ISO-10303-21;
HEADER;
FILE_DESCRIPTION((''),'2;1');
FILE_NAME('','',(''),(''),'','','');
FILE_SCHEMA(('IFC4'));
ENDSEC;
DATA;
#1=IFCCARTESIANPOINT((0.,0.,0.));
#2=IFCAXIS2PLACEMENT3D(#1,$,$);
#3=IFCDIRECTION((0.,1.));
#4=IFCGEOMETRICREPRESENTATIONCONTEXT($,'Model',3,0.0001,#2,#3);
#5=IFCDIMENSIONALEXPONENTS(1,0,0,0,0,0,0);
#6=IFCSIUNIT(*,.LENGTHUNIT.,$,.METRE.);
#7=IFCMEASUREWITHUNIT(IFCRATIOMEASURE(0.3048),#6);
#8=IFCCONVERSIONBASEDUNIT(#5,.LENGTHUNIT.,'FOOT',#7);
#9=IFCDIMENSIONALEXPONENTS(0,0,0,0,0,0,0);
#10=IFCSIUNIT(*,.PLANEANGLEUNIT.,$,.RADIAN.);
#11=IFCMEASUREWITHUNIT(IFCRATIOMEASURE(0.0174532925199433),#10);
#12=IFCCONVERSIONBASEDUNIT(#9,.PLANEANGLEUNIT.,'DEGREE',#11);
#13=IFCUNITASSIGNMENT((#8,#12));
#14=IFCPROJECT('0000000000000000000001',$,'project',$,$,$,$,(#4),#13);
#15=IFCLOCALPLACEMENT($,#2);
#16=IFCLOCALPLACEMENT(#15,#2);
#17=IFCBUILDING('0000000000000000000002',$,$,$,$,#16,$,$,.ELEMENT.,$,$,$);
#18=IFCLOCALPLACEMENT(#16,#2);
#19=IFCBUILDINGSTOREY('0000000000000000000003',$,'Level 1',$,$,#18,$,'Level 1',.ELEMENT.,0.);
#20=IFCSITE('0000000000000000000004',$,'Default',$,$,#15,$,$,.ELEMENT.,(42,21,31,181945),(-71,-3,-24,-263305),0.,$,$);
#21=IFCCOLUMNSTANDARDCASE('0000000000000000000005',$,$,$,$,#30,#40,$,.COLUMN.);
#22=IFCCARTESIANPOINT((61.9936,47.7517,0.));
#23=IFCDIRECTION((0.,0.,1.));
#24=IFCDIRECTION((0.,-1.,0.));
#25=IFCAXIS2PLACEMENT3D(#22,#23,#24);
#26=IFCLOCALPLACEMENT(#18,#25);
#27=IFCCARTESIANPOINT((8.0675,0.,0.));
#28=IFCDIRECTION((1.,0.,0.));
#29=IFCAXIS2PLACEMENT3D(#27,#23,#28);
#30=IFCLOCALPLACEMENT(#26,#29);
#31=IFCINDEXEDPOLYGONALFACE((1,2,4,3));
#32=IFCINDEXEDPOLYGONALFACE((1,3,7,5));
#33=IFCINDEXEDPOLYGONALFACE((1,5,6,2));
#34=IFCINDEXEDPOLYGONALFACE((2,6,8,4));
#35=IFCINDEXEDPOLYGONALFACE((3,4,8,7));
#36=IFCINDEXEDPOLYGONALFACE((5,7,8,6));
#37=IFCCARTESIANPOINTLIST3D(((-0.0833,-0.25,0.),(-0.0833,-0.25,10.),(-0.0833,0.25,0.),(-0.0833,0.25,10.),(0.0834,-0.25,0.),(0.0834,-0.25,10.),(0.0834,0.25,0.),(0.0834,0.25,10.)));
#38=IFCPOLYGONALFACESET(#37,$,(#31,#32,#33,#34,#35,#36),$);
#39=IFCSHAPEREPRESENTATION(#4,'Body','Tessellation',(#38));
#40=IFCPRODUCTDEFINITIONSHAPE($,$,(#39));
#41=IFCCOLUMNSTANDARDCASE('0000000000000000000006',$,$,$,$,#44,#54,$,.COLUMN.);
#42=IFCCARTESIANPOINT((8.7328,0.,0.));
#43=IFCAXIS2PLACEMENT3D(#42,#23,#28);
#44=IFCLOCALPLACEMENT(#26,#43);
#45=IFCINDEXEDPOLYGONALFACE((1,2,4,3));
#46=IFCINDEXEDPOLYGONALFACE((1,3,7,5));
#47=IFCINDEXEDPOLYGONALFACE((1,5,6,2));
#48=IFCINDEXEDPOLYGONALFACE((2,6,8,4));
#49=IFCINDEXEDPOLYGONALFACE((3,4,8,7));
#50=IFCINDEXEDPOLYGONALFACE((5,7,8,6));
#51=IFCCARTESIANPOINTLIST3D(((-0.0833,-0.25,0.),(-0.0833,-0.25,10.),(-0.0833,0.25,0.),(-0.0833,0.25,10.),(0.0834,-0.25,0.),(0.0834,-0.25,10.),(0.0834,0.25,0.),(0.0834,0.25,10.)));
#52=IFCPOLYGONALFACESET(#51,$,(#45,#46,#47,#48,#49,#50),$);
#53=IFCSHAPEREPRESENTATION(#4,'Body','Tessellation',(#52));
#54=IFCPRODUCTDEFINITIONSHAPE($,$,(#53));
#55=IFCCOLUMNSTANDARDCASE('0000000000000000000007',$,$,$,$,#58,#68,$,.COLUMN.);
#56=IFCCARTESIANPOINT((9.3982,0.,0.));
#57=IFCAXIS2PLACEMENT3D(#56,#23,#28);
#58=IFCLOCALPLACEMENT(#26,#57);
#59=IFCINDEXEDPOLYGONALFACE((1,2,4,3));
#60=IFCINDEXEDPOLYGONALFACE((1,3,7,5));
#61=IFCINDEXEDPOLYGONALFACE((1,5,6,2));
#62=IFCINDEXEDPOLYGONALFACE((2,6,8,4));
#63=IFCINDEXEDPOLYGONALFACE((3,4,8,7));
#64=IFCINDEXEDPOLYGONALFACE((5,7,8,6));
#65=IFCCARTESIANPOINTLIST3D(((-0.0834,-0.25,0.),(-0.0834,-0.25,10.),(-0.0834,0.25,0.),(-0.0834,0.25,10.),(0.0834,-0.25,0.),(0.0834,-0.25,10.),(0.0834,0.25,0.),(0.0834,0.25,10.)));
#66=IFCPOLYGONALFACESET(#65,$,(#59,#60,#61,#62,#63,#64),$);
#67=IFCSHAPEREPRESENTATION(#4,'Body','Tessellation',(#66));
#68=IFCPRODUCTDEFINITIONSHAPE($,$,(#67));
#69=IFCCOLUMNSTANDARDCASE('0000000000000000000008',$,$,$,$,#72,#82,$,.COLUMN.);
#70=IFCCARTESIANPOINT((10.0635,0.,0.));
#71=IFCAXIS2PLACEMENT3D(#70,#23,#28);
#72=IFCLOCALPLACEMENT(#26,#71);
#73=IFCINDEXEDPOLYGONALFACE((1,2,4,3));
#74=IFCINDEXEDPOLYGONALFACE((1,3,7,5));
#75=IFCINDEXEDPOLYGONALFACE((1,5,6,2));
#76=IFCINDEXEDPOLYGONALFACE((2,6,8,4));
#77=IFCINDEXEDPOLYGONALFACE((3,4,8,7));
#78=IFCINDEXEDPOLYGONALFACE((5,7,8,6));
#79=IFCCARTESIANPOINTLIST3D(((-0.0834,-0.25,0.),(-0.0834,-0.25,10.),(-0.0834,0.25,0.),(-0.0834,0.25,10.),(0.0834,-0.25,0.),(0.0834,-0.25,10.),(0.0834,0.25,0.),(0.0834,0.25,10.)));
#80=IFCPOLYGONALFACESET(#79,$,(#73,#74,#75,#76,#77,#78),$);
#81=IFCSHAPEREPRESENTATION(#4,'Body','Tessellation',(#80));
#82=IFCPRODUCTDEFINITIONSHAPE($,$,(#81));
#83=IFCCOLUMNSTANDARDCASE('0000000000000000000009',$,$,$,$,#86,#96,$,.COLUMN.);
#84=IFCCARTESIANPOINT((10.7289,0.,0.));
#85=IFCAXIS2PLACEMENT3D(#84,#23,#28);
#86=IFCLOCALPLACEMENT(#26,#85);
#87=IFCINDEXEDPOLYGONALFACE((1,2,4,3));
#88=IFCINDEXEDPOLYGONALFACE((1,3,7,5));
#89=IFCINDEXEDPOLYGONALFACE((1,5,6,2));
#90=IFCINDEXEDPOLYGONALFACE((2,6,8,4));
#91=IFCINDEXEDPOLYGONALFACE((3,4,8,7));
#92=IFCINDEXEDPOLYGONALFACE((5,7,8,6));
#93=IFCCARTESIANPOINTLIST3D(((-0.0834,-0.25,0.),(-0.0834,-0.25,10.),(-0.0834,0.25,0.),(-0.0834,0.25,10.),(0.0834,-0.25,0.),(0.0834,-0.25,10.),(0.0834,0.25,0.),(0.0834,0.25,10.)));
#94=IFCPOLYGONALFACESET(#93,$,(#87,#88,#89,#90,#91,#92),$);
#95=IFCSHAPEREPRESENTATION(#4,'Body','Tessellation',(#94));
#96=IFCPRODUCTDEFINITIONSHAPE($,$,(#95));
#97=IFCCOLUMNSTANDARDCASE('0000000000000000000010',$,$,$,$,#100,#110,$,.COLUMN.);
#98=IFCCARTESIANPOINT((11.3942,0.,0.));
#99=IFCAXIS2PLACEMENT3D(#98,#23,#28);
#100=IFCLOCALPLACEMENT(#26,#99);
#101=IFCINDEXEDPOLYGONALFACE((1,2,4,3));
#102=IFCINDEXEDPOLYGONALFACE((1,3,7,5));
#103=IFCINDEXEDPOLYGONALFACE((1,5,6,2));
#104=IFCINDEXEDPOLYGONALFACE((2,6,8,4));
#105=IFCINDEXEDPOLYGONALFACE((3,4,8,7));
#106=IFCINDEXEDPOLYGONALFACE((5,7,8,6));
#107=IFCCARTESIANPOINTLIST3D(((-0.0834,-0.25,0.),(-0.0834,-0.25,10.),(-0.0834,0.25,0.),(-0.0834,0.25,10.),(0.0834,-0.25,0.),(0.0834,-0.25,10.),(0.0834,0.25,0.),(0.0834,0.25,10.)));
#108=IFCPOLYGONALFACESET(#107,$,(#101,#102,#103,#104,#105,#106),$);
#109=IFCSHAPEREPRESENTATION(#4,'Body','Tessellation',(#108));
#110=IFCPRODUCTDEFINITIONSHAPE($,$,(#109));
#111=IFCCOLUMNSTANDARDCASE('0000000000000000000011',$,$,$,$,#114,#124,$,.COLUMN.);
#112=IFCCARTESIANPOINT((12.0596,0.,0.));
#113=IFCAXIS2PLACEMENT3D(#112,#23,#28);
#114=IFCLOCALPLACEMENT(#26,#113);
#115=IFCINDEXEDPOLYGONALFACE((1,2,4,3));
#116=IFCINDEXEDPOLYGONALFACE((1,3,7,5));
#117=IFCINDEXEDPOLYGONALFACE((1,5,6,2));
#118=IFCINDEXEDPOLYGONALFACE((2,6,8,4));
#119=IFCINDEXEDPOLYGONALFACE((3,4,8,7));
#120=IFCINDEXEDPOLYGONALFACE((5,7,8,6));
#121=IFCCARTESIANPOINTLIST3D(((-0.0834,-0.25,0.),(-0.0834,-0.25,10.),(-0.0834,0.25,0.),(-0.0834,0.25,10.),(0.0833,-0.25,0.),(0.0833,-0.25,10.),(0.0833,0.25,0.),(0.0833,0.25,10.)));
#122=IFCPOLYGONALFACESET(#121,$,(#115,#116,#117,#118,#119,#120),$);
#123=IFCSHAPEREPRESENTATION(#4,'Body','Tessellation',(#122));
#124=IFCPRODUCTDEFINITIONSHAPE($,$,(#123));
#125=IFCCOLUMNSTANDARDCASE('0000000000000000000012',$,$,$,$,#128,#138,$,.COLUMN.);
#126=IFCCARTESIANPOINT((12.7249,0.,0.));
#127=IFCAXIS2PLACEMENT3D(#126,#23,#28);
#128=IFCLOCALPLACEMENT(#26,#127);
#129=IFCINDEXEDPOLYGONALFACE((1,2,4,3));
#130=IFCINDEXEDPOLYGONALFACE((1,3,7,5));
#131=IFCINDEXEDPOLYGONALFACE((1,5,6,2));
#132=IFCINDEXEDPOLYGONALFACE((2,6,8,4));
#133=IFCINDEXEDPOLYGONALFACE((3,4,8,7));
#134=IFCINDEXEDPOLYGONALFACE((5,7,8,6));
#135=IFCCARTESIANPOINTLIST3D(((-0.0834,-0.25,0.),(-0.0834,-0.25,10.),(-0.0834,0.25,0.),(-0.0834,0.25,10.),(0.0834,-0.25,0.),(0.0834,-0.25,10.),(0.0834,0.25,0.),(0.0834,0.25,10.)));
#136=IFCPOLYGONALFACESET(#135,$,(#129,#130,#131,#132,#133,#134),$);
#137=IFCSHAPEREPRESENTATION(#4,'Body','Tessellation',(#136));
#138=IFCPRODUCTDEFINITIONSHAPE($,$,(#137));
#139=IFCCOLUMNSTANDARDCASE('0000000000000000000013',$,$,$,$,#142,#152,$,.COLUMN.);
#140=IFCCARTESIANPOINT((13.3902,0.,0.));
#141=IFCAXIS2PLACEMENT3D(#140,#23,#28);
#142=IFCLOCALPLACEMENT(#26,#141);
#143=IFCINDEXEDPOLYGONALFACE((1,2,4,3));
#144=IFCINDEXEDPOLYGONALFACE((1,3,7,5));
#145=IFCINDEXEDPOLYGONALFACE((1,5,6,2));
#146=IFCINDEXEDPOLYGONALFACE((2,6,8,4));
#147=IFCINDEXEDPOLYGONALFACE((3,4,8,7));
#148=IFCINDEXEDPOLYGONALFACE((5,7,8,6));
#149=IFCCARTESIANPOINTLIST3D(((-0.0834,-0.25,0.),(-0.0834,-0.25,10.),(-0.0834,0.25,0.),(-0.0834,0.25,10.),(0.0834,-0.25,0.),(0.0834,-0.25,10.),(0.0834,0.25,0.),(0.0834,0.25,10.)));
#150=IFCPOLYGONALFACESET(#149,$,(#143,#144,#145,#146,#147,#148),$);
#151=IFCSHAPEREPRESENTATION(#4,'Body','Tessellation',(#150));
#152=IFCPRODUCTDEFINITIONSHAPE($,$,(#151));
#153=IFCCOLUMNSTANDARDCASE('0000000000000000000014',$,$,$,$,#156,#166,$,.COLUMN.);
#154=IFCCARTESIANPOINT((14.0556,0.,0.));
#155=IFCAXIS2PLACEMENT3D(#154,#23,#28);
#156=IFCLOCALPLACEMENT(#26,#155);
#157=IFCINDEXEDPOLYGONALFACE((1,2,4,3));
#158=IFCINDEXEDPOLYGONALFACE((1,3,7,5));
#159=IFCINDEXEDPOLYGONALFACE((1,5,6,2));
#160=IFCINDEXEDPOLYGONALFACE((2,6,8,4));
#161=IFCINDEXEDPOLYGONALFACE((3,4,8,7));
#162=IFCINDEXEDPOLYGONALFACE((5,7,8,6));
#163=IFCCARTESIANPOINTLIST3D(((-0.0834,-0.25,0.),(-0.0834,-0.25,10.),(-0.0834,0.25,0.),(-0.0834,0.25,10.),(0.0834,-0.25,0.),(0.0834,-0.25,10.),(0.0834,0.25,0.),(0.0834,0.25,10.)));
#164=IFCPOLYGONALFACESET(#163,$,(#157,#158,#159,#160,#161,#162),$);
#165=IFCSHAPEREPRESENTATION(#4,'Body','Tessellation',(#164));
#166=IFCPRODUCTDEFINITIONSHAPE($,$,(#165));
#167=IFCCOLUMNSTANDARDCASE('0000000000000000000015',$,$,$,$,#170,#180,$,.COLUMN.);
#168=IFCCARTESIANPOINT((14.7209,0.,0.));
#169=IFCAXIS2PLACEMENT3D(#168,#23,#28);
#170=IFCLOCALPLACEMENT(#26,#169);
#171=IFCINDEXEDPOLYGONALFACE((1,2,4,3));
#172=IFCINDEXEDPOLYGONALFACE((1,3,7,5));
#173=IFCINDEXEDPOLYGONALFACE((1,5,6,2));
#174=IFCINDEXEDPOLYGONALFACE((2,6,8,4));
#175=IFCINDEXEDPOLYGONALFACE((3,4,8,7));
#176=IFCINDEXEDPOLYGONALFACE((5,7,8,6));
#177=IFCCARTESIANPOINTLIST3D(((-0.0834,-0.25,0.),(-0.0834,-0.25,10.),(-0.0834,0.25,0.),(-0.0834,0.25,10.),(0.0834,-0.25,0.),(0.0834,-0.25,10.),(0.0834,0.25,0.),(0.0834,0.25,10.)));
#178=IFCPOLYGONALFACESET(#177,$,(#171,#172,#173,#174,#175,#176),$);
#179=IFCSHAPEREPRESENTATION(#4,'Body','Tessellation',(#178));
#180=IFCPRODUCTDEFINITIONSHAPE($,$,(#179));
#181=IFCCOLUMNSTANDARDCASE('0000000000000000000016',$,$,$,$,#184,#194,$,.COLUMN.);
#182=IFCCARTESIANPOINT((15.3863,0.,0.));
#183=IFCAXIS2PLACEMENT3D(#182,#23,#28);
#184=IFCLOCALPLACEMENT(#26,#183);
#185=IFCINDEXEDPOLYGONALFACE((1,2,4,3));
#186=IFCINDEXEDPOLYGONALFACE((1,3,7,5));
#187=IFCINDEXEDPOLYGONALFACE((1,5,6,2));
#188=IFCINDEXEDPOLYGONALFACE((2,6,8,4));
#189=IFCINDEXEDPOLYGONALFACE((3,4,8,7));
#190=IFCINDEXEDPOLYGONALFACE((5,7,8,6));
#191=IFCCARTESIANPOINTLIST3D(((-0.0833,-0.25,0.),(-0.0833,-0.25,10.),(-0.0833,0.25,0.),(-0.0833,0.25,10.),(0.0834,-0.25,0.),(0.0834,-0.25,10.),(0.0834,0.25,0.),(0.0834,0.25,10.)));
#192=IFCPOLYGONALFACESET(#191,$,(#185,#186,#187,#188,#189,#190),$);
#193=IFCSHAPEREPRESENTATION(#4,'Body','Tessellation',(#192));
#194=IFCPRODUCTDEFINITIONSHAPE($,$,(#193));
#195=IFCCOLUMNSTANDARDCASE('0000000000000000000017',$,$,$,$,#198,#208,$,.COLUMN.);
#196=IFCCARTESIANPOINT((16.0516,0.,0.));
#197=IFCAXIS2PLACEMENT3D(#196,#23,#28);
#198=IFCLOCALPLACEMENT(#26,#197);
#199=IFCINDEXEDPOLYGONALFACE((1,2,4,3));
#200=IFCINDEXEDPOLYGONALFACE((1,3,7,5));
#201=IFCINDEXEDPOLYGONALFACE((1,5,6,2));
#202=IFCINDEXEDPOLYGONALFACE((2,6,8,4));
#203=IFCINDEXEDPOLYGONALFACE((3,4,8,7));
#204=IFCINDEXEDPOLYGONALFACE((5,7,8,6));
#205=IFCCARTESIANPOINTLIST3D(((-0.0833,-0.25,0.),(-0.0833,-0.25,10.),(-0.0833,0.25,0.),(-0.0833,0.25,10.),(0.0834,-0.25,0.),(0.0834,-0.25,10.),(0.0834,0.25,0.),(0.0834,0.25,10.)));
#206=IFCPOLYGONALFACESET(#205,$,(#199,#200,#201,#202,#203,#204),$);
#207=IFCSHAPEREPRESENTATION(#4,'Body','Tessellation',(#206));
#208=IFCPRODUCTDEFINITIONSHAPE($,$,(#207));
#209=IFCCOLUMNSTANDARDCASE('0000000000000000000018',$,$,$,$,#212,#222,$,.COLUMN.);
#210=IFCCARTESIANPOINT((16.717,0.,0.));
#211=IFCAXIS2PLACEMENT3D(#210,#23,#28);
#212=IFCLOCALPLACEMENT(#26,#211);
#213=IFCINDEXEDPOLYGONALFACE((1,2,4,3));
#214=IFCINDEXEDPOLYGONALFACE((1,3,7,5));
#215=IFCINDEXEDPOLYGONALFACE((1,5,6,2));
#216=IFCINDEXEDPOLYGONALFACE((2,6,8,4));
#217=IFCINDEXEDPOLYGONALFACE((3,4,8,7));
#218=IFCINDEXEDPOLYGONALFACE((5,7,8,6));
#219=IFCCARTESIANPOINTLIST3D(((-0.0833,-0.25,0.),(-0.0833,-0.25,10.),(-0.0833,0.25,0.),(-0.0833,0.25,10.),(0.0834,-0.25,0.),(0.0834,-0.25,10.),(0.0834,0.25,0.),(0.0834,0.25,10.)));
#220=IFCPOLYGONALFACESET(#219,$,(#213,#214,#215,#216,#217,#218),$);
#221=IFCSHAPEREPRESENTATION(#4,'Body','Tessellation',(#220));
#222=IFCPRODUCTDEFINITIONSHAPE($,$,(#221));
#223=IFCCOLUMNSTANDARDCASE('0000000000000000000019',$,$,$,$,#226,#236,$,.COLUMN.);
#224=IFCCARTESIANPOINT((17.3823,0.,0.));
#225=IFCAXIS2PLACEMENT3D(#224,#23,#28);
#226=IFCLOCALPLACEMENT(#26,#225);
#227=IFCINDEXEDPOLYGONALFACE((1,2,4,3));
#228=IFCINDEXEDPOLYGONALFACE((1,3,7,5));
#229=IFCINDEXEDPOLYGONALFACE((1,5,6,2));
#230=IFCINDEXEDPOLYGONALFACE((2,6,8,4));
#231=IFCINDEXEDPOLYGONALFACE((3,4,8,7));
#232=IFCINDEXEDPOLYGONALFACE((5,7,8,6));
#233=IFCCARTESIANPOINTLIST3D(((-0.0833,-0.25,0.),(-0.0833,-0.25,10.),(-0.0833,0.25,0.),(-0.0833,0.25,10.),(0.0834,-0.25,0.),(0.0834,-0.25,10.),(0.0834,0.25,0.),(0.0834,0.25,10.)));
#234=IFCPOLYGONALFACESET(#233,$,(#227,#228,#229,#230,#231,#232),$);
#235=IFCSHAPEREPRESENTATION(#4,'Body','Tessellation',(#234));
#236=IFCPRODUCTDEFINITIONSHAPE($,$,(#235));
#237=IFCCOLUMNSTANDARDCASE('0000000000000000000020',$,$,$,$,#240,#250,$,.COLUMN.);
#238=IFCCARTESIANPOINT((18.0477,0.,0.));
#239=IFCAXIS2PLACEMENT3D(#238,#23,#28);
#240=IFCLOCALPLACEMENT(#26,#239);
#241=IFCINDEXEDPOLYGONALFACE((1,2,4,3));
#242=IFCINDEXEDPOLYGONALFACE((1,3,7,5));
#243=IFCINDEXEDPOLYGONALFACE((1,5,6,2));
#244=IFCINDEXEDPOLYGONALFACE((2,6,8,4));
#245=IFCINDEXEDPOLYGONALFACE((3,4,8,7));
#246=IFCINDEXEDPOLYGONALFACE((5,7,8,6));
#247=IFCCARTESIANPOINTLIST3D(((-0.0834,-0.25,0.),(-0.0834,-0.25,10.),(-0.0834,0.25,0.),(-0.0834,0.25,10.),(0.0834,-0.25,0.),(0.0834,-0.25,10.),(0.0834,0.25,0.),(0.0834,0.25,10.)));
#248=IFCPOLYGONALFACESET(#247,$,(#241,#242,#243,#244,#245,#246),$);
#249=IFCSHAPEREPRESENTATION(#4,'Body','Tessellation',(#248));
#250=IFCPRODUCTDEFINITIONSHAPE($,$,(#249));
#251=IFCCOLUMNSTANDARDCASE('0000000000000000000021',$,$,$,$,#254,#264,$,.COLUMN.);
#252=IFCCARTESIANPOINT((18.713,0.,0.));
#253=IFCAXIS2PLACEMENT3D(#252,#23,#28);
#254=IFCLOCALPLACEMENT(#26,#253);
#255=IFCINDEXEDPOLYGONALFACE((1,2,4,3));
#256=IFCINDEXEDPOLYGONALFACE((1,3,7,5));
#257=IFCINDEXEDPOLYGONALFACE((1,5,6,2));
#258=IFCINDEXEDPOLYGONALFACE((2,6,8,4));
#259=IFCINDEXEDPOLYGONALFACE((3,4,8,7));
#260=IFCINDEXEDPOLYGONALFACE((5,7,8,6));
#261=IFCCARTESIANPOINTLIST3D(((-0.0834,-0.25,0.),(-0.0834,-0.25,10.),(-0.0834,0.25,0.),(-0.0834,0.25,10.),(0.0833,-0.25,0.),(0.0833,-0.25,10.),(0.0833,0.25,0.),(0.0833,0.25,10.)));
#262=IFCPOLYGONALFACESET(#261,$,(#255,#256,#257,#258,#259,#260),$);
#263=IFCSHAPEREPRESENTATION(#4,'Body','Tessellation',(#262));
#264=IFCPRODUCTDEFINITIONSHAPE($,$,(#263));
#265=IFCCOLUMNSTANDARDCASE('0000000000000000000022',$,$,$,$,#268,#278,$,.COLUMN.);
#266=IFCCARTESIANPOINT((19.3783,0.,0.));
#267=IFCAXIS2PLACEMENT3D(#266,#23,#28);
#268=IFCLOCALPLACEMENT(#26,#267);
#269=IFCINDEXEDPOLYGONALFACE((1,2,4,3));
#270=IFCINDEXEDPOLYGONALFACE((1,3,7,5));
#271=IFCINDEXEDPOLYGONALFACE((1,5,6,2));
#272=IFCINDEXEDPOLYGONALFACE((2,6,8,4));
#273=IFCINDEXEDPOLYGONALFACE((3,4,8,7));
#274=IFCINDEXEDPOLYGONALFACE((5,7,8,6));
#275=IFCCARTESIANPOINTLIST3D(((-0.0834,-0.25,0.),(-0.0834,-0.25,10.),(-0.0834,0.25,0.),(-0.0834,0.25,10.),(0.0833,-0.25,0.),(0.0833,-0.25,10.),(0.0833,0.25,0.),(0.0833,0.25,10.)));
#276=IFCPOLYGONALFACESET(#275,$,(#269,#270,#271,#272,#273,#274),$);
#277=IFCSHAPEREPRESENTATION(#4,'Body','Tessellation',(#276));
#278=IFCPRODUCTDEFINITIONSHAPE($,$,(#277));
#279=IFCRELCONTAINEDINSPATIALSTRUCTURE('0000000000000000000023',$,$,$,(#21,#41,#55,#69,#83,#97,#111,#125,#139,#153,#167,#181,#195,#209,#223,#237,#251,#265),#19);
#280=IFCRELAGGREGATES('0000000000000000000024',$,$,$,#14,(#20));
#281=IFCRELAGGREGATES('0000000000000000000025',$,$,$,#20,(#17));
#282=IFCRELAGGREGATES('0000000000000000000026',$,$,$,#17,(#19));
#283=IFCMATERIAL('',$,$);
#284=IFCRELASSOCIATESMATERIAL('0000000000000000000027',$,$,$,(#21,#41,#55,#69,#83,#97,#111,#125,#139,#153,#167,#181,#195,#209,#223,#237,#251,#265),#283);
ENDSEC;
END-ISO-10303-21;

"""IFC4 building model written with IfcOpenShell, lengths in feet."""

from ifc_helpers import new_model, entity, si_unit, converted_unit, direction, frame, origin, place, context, project, spatial, rectangle, extrude, material, element, save


model = new_model("IFC4")

# Units and contexts
model_context = context("Model", 3, precision=0.0001, world=origin(), true_north=direction((0.0, 1.0)))
ifc_project = project(units=[converted_unit("LENGTHUNIT", "FOOT", entity("IfcRatioMeasure", 0.3048), si_unit("LENGTHUNIT", "METRE"), dimensions=[1, 0, 0, 0, 0, 0, 0]), converted_unit("PLANEANGLEUNIT", "DEGREE", entity("IfcRatioMeasure", 0.0174532925199433), si_unit("PLANEANGLEUNIT", "RADIAN"), dimensions=[0, 0, 0, 0, 0, 0, 0])], contexts=[model_context])

# Site, building, storey
site_placement = place(None, origin())
site = spatial("IfcSite", under=ifc_project, at=site_placement, Name="Default", CompositionType="ELEMENT", RefLatitude=(42, 21, 31, 181945), RefLongitude=(-71, -3, -24, -263305), RefElevation=0.0)
building_placement = place(site_placement, origin())
building = spatial("IfcBuilding", under=site, at=building_placement, CompositionType="ELEMENT")
storey_placement = place(building_placement, origin())
storey = spatial("IfcBuildingStorey", under=building, at=storey_placement, Name="Level 1", LongName="Level 1", CompositionType="ELEMENT", Elevation=0.0)

# Columns
ifc_material_1 = material(Name="")
placement = place(storey_placement, frame((61.9936, 47.7517, 0.0), z_axis=(0.0, 0.0, 1.0), x_axis=(0.0, -1.0, 0.0)))
for number, where, z_axis, x_axis in (
    (1, (8.0675, 0.0, 0.0), (0.0, 0.0, 1.0), (1.0, 0.0, 0.0)),
    (2, (8.7328, 0.0, 0.0), (0.0, 0.0, 1.0), (1.0, 0.0, 0.0)),
    (3, (9.3982, 0.0, 0.0), (0.0, 0.0, 1.0), (1.0, 0.0, 0.0)),
    (4, (10.0635, 0.0, 0.0), (0.0, 0.0, 1.0), (1.0, 0.0, 0.0)),
    (5, (10.7289, 0.0, 0.0), (0.0, 0.0, 1.0), (1.0, 0.0, 0.0)),
    (6, (11.3942, 0.0, 0.0), (0.0, 0.0, 1.0), (1.0, 0.0, 0.0)),
    (7, (12.0596, 0.0, 0.0), (0.0, 0.0, 1.0), (1.0, 0.0, 0.0)),
    (8, (12.7249, 0.0, 0.0), (0.0, 0.0, 1.0), (1.0, 0.0, 0.0)),
    (9, (13.3902, 0.0, 0.0), (0.0, 0.0, 1.0), (1.0, 0.0, 0.0)),
    (10, (14.0556, 0.0, 0.0), (0.0, 0.0, 1.0), (1.0, 0.0, 0.0)),
    (11, (14.7209, 0.0, 0.0), (0.0, 0.0, 1.0), (1.0, 0.0, 0.0)),
    (12, (15.3863, 0.0, 0.0), (0.0, 0.0, 1.0), (1.0, 0.0, 0.0)),
    (13, (16.0516, 0.0, 0.0), (0.0, 0.0, 1.0), (1.0, 0.0, 0.0)),
    (14, (16.717, 0.0, 0.0), (0.0, 0.0, 1.0), (1.0, 0.0, 0.0)),
    (15, (17.3823, 0.0, 0.0), (0.0, 0.0, 1.0), (1.0, 0.0, 0.0)),
    (16, (18.0477, 0.0, 0.0), (0.0, 0.0, 1.0), (1.0, 0.0, 0.0)),
    (17, (18.713, 0.0, 0.0), (0.0, 0.0, 1.0), (1.0, 0.0, 0.0)),
    (18, (19.3783, 0.0, 0.0), (0.0, 0.0, 1.0), (1.0, 0.0, 0.0)),
):
    element("IfcColumnStandardCase", number, at=place(placement, frame(where, z_axis=z_axis, x_axis=x_axis)), inside=storey, material=ifc_material_1, PredefinedType="COLUMN", context=model_context, shape_type="SweptSolid", body=[
        extrude(rectangle(XDim=0.1667, YDim=0.5), origin(), (0.0, 0.0, 1.0), 10.0),
    ])

save(model, "model.ifc")
